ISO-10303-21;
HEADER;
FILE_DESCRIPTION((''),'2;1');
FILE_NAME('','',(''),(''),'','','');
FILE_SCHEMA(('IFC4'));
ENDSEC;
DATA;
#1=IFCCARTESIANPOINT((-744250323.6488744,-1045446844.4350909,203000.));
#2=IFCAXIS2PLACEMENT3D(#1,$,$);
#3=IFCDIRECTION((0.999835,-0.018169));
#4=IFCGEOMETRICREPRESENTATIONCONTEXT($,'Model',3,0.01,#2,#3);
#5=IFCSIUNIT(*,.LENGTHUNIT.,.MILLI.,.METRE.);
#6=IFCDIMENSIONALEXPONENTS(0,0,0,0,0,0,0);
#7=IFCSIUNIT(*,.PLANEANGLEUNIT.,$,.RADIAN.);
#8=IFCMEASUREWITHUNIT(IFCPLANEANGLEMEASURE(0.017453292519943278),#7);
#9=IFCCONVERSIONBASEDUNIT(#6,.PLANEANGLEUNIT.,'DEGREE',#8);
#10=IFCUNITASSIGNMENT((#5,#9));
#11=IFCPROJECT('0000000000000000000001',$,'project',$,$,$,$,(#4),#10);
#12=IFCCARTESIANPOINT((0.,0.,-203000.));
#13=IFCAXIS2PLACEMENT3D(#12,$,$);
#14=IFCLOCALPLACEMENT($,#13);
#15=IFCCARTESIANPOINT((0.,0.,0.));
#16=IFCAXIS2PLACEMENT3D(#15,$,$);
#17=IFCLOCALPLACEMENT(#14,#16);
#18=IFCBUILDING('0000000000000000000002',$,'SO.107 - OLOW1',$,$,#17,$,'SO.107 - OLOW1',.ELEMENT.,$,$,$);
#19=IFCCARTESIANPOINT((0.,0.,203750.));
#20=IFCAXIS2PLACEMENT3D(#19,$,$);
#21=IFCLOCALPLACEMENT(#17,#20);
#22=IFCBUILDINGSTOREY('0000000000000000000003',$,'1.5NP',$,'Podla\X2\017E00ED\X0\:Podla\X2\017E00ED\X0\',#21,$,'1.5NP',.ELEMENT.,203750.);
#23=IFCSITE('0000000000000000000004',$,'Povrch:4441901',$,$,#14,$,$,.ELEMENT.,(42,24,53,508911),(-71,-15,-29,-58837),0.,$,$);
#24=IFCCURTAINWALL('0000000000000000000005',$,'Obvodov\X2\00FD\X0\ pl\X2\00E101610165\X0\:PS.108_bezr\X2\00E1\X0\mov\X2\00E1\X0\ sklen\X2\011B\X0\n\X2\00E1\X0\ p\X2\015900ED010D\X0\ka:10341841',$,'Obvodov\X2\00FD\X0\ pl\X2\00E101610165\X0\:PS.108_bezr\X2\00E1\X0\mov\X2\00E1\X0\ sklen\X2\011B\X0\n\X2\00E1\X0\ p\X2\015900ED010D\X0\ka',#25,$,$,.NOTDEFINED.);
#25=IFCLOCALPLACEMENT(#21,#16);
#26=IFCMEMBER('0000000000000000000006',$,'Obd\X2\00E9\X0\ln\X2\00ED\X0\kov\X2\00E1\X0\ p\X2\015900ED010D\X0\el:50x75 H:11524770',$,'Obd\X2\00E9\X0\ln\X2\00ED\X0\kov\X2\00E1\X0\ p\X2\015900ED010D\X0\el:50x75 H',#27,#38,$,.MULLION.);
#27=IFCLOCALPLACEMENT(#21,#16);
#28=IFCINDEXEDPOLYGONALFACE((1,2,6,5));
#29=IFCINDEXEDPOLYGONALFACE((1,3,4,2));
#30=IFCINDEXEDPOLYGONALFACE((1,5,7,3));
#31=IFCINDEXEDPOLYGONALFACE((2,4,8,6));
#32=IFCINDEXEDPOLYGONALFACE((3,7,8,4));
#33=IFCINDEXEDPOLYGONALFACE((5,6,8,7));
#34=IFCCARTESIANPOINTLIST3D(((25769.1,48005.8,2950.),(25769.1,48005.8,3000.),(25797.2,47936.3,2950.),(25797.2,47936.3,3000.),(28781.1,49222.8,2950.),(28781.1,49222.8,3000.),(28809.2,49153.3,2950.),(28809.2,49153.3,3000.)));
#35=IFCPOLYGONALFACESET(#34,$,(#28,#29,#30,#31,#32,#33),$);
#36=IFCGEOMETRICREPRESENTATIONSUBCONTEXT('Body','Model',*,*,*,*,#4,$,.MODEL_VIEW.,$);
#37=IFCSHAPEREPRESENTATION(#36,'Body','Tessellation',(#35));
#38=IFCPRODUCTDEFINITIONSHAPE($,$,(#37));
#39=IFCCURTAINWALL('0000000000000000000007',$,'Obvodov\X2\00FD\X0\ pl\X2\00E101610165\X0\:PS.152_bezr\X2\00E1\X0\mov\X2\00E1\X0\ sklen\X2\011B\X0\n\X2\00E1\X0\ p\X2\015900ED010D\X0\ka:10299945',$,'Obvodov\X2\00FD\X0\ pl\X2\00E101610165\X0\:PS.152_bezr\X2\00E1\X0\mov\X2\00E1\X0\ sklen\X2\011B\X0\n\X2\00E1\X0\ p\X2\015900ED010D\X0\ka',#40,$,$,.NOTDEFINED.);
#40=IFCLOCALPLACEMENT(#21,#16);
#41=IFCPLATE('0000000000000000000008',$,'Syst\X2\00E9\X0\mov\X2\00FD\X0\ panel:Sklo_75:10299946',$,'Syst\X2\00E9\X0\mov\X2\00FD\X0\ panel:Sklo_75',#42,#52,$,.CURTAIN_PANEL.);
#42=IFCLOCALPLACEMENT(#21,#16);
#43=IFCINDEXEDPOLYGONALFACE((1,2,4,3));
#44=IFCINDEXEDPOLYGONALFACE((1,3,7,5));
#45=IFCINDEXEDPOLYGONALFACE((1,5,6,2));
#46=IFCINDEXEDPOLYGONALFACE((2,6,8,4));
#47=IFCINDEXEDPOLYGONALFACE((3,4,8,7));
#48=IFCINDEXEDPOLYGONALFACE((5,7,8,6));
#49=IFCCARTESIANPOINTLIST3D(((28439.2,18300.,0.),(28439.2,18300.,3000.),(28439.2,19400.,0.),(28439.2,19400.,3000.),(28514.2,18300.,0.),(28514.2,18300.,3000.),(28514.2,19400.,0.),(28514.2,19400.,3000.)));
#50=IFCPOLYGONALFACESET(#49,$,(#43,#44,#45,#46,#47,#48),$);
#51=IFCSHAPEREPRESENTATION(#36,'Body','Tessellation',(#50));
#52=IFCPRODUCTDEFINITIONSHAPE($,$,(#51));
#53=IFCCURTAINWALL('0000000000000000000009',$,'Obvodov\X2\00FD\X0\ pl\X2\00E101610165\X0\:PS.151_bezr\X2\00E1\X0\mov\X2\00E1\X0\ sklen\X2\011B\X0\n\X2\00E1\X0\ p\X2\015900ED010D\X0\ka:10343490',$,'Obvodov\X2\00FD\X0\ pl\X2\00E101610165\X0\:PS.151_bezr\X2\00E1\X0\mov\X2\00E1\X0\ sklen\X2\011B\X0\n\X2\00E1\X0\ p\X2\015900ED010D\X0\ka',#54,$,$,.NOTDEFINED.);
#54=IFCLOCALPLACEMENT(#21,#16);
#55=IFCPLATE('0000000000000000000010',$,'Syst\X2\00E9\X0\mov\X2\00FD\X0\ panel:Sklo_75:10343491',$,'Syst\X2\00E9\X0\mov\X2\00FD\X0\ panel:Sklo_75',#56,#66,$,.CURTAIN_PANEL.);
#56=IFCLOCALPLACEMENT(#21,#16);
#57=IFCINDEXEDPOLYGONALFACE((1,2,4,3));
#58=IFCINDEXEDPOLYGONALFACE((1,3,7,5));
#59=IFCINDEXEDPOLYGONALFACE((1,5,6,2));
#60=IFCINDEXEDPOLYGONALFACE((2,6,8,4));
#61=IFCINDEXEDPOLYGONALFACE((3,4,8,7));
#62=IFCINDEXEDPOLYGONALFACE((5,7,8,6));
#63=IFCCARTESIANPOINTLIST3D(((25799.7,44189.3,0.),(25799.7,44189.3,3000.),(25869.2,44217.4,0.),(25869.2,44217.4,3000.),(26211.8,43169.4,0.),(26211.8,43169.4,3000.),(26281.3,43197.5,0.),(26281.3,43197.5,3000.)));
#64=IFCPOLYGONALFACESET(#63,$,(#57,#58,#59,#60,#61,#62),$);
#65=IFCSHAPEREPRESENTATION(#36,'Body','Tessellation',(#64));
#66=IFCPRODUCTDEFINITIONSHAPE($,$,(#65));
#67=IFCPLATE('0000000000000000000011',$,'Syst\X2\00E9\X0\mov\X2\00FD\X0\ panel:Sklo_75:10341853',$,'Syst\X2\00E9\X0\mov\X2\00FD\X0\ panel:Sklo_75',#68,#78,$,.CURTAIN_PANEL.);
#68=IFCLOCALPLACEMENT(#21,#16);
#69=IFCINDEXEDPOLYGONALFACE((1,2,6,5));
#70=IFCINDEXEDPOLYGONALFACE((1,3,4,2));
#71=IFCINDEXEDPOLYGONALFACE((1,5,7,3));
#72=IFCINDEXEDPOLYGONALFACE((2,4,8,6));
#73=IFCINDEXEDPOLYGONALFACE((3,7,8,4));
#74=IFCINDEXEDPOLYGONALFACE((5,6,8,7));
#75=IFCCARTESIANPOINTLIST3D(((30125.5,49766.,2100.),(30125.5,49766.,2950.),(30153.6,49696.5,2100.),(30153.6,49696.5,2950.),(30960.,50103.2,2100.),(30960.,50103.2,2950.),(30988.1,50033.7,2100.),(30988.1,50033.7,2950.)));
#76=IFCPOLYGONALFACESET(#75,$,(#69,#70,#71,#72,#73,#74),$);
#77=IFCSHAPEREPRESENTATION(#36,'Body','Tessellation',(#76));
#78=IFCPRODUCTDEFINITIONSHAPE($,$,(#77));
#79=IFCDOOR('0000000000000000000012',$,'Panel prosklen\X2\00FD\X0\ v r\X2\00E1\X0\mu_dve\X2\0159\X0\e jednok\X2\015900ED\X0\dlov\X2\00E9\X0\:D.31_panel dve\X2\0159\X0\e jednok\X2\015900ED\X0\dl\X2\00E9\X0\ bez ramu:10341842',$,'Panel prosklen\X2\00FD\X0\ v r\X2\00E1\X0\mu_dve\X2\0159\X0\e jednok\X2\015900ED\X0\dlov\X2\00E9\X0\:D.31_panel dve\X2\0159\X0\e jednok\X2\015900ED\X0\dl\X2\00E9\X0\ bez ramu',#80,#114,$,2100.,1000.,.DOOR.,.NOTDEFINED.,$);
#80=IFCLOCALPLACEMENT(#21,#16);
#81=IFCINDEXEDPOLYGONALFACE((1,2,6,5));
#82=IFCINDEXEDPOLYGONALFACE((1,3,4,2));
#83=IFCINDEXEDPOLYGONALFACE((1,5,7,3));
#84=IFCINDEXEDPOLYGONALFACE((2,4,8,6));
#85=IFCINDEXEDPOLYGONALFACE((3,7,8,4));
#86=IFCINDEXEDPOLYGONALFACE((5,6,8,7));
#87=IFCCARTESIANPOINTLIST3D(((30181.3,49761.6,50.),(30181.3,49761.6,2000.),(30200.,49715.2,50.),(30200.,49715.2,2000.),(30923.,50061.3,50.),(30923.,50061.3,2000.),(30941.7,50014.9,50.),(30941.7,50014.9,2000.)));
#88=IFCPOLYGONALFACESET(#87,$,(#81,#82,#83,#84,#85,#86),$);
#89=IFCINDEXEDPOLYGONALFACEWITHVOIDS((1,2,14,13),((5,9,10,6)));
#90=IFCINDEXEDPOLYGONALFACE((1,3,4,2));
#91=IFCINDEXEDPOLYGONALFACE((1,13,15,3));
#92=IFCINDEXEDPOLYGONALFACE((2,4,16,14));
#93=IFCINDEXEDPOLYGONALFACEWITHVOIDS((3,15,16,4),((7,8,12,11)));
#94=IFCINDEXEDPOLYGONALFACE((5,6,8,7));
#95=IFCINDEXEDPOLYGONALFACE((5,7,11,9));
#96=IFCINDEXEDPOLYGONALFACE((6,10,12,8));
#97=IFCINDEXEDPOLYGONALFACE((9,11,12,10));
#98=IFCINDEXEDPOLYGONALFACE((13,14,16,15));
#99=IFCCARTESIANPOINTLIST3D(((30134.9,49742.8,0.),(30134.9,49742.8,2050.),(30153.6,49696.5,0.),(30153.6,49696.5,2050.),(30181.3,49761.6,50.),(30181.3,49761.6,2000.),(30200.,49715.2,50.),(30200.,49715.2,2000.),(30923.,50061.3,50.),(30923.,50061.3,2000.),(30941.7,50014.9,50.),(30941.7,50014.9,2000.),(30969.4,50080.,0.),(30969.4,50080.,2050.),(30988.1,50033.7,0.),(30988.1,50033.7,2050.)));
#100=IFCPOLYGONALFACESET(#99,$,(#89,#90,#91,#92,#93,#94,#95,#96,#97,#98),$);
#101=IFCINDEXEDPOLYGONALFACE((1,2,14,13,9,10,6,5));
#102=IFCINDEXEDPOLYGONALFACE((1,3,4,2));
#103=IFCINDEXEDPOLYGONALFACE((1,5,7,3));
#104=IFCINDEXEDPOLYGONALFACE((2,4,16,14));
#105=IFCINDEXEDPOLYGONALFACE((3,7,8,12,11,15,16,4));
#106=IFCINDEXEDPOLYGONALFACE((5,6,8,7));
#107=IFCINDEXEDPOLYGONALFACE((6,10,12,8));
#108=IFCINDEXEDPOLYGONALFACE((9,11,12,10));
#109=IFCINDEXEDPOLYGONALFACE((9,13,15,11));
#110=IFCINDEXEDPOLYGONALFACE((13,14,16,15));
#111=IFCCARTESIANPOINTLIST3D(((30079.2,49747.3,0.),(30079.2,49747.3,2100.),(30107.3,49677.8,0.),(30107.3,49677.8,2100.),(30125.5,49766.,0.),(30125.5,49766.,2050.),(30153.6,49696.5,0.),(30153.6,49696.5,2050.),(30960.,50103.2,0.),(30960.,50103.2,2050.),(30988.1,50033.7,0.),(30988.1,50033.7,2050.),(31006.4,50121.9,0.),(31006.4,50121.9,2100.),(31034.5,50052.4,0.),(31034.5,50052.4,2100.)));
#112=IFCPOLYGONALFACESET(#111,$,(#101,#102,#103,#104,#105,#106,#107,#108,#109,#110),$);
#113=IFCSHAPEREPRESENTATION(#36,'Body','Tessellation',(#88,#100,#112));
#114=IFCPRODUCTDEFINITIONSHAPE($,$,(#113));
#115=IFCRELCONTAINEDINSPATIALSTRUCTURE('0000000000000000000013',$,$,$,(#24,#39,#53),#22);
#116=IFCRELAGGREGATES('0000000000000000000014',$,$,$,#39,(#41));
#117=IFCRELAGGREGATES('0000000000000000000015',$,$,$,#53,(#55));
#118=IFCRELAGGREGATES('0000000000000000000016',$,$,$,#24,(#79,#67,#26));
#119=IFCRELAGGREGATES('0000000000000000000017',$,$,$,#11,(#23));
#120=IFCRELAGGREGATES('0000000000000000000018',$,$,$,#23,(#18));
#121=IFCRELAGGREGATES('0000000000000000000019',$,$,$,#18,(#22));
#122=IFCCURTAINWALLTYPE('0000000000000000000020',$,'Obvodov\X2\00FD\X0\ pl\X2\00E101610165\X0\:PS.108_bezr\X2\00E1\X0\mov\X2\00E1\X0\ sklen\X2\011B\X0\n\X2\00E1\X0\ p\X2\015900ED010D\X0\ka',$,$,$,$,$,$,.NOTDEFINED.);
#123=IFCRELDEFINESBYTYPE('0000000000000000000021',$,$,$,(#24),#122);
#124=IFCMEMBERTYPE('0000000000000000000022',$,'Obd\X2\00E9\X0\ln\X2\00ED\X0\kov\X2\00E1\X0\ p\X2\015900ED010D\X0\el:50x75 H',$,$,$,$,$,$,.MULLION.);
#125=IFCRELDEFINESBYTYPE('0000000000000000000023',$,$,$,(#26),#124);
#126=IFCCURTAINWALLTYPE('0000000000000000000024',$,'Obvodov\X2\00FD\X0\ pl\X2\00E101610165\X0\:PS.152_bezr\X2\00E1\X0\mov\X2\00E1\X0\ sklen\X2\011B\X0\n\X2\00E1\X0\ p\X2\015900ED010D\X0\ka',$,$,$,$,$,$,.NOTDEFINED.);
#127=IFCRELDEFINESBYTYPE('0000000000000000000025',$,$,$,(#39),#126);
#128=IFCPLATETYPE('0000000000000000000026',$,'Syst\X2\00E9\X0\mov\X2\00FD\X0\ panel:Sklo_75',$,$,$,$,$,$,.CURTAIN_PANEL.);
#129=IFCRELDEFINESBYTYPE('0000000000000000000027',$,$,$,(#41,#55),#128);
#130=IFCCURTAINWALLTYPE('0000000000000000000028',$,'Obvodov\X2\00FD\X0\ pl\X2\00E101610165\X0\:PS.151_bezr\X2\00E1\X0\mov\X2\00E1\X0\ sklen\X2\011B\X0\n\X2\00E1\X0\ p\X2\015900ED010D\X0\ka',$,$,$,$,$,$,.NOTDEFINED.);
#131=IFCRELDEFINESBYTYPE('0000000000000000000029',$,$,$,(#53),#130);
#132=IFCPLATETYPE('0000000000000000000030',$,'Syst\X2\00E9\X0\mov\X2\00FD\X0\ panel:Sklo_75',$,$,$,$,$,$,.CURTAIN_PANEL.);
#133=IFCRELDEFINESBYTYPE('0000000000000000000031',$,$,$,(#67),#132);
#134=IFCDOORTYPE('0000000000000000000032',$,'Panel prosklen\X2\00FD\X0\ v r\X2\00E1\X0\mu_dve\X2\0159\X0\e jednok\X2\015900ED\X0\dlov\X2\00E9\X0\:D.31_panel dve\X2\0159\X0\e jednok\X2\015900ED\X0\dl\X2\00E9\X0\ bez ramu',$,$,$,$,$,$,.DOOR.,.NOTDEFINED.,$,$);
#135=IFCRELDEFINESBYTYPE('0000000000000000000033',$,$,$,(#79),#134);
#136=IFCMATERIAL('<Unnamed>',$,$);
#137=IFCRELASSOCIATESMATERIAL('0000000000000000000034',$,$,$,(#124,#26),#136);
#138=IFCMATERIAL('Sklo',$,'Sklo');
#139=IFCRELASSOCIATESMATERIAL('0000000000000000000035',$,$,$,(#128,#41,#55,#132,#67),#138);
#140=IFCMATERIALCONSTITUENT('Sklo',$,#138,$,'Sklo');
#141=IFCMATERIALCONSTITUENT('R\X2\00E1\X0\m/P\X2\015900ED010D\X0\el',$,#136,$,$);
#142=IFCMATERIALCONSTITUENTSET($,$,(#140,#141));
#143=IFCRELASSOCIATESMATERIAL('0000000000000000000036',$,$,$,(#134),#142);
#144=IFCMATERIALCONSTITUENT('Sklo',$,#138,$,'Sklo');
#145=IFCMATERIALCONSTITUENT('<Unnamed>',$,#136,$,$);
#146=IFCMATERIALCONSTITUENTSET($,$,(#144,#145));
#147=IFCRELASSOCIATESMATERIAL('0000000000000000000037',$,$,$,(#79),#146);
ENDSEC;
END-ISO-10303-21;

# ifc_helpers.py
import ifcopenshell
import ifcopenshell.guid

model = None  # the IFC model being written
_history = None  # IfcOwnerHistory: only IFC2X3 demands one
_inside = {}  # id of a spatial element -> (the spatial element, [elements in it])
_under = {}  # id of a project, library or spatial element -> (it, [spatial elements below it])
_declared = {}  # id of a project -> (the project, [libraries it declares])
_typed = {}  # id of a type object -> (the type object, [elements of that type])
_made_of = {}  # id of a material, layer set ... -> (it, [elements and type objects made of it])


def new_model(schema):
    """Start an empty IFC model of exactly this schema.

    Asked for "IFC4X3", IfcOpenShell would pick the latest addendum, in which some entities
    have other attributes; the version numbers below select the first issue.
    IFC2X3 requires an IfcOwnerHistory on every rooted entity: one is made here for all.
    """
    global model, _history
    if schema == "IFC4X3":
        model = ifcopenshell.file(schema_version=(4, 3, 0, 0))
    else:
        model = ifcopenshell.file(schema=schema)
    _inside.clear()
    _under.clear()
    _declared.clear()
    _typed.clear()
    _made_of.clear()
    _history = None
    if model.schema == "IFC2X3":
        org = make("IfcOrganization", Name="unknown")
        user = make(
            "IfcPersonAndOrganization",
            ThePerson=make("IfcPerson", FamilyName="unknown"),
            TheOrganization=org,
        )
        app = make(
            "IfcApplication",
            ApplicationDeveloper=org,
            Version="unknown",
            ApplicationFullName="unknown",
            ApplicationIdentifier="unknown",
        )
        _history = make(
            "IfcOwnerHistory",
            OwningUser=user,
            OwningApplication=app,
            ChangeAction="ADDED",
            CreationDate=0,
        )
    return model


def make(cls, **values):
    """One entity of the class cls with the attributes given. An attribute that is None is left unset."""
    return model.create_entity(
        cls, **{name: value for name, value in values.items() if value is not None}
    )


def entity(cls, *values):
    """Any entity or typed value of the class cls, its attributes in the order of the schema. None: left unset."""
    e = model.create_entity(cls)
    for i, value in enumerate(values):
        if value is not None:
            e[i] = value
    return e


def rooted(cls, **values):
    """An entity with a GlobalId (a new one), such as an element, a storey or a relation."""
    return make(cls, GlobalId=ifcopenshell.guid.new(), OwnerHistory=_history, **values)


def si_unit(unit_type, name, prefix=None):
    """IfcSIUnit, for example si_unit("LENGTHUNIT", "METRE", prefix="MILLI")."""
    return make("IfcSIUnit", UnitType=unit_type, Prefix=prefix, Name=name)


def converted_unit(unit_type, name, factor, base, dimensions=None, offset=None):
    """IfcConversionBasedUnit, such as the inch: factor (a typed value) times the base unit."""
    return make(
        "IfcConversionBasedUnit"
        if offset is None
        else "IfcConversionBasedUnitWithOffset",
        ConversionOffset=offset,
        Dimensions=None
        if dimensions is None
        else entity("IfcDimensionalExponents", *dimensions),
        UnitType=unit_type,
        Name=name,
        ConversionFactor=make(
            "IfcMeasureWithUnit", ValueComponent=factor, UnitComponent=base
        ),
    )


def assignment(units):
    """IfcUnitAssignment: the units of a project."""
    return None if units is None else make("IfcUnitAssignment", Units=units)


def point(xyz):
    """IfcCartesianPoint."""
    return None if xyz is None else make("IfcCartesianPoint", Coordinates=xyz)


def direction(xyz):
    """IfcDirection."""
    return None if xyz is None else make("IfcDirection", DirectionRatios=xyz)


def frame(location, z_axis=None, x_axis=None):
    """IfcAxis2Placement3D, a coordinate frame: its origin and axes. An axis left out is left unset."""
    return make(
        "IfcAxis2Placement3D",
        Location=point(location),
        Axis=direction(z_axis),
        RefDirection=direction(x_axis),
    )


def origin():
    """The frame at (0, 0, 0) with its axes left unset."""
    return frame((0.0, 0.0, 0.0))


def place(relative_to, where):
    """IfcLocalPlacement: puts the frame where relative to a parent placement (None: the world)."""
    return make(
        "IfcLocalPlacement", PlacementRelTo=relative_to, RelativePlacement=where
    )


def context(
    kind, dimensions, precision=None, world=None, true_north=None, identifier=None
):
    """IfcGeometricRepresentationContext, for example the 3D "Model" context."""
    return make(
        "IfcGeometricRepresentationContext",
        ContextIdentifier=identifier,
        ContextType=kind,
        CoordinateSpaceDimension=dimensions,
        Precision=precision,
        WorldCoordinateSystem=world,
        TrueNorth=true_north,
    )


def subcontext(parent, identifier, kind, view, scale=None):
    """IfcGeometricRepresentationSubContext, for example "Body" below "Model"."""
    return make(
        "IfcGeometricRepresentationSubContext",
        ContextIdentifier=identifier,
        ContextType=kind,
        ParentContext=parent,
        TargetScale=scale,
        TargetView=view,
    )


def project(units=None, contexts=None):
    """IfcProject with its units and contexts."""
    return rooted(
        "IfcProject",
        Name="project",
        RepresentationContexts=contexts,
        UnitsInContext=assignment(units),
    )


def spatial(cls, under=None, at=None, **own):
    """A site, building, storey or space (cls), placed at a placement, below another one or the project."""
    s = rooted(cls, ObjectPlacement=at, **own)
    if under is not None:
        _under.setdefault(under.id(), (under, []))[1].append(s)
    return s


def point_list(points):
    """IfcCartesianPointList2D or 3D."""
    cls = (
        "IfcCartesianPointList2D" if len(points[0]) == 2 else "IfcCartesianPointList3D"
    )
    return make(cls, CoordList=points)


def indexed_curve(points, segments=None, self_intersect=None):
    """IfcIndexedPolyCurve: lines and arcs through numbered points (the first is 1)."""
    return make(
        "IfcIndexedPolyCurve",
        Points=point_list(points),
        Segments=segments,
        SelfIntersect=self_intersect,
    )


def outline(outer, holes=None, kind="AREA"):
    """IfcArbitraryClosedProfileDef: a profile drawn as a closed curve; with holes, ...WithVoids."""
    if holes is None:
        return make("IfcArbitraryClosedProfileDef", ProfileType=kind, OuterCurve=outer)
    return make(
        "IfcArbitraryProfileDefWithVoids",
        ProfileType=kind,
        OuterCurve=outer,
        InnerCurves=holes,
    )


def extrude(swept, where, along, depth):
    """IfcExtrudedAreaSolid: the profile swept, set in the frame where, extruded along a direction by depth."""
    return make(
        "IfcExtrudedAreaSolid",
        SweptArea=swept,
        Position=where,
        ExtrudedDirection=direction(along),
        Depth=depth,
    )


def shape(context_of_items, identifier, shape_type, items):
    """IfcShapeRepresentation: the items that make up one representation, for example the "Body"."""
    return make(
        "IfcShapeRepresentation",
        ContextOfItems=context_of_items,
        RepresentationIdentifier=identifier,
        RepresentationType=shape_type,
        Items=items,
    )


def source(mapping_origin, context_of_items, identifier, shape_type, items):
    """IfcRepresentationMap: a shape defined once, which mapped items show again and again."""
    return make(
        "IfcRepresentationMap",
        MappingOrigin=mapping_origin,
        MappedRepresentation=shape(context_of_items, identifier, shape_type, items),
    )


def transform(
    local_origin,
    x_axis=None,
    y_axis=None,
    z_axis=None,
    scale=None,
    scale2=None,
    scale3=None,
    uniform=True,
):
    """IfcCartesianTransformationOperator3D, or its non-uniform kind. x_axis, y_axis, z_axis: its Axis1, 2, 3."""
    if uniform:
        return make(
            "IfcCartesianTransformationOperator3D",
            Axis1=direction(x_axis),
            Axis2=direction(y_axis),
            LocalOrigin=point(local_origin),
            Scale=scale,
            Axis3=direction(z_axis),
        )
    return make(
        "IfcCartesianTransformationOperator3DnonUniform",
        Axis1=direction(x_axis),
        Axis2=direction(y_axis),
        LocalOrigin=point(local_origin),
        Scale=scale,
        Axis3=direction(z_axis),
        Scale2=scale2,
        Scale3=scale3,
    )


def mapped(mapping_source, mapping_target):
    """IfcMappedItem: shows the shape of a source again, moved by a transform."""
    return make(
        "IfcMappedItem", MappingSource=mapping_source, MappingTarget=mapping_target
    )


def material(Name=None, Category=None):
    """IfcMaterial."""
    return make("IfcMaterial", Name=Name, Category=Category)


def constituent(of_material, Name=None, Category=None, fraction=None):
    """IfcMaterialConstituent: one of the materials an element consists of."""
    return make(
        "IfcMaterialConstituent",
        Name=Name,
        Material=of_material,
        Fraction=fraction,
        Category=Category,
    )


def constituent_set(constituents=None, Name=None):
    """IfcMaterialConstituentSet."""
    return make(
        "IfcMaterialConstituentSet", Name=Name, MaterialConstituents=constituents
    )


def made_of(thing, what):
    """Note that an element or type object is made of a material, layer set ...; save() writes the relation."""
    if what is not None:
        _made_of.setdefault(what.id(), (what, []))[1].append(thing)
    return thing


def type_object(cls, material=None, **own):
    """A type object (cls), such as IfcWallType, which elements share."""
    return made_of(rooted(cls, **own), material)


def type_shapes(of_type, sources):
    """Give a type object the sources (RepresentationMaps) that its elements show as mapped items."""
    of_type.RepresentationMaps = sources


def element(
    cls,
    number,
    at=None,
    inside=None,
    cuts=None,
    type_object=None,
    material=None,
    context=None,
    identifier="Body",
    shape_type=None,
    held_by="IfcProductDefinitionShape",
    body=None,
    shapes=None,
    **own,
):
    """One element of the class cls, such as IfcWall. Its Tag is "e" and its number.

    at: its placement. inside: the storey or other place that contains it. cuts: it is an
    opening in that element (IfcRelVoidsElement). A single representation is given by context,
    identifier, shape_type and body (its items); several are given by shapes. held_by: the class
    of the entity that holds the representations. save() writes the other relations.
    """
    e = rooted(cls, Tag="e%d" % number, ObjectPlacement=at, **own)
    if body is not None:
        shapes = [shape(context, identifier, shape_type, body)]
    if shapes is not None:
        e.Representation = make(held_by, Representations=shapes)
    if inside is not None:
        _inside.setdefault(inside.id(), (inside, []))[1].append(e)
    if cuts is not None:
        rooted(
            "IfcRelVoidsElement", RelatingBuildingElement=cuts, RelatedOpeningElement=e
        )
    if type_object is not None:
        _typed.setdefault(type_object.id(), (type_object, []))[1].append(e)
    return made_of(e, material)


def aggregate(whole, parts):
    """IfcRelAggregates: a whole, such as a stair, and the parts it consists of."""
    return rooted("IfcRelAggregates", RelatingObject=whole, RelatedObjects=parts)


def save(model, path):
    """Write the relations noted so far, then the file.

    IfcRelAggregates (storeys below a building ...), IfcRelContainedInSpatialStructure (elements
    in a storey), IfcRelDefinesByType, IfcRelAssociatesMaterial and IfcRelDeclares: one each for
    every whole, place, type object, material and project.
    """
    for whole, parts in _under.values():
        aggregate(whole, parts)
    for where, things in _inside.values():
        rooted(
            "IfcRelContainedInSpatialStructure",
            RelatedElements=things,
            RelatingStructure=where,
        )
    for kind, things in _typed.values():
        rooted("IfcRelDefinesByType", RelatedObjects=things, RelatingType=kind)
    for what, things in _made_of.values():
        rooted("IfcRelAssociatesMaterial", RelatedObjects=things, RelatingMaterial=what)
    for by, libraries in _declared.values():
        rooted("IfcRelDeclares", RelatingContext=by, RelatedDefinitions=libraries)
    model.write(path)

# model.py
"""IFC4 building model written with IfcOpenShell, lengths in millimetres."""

from ifc_helpers import new_model, entity, si_unit, converted_unit, direction, frame, origin, place, context, subcontext, project, spatial, indexed_curve, outline, extrude, source, transform, mapped, material, constituent, constituent_set, type_object, type_shapes, element, aggregate, save


model = new_model("IFC4")

# Units and contexts
model_context = context("Model", 3, precision=0.01, world=frame((-744250323.6488744, -1045446844.4350909, 203000.0)), true_north=direction((0.999835, -0.018169)))
body_context = subcontext(model_context, "Body", "Model", "MODEL_VIEW")
ifc_project = project(units=[si_unit("LENGTHUNIT", "METRE", prefix="MILLI"), converted_unit("PLANEANGLEUNIT", "DEGREE", entity("IfcPlaneAngleMeasure", 0.017453292519943278), si_unit("PLANEANGLEUNIT", "RADIAN"), dimensions=[0, 0, 0, 0, 0, 0, 0])], contexts=[model_context])

# Site, building, storey
site_placement = place(None, frame((0.0, 0.0, -203000.0)))
site = spatial("IfcSite", under=ifc_project, at=site_placement, Name="Povrch:4441901", CompositionType="ELEMENT", RefLatitude=(42, 24, 53, 508911), RefLongitude=(-71, -15, -29, -58837), RefElevation=0.0)
building_placement = place(site_placement, origin())
building = spatial("IfcBuilding", under=site, at=building_placement, Name="SO.107 - OLOW1", LongName="SO.107 - OLOW1", CompositionType="ELEMENT")
storey_placement = place(building_placement, frame((0.0, 0.0, 203750.0)))
storey = spatial("IfcBuildingStorey", under=building, at=storey_placement, Name="1.5NP", ObjectType="Podlaží:Podlaží", LongName="1.5NP", CompositionType="ELEMENT", Elevation=203750.0)

# Curtain wall, member
ifc_material_1 = material(Name="<Unnamed>")
curtain_wall_type_1 = type_object("IfcCurtainWallType", Name="Obvodový plášť:PS.108_bezrámová skleněná příčka", PredefinedType="NOTDEFINED")
curtain_wall_1_placement = place(storey_placement, frame((0.0, 0.0, -203750.0)))
curtain_wall_1 = element("IfcCurtainWall", 1, at=curtain_wall_1_placement, inside=storey, type_object=curtain_wall_type_1, Name="Obvodový plášť:PS.108_bezrámová skleněná příčka:10341841", ObjectType="Obvodový plášť:PS.108_bezrámová skleněná příčka", PredefinedType="NOTDEFINED")
member_type_1 = type_object("IfcMemberType", Name="Obdélníková příčel:50x75 H", PredefinedType="MULLION", material=ifc_material_1)
shared_shape_1 = source(origin(), body_context, "Body", "SweptSolid", [
    extrude(outline(indexed_curve([(-25.0, -37.5), (25.0, -37.5), (25.0, 37.5), (-25.0, 37.5), (-25.0, -37.5)], self_intersect=False)), frame((-25.0, -37.5, -3248.6), z_axis=(0.0, 0.0, 1.0), x_axis=(-1.0, 0.0, 0.0)), (0.0, 0.0, 1.0), 3248.6),
])
type_shapes(member_type_1, [shared_shape_1])
member_1_placement = place(curtain_wall_1_placement, frame((25769.1, 48005.8, 206750.0), z_axis=(-0.927176, -0.374626, 0.0), x_axis=(0.0, 0.0, 1.0)))
member_1 = element("IfcMember", 2, at=member_1_placement, type_object=member_type_1, material=ifc_material_1, Name="Obdélníková příčel:50x75 H:11524770", ObjectType="Obdélníková příčel:50x75 H", PredefinedType="MULLION", context=body_context, shape_type="MappedRepresentation", body=[
    mapped(shared_shape_1, transform((0.0, 0.0, 0.0), scale=1.0)),
])

# Curtain walls, plates
curtain_wall_type_2 = type_object("IfcCurtainWallType", Name="Obvodový plášť:PS.152_bezrámová skleněná příčka", PredefinedType="NOTDEFINED")
curtain_wall_2_placement = place(storey_placement, frame((0.0, 0.0, -203750.0)))
curtain_wall_2 = element("IfcCurtainWall", 3, at=curtain_wall_2_placement, inside=storey, type_object=curtain_wall_type_2, Name="Obvodový plášť:PS.152_bezrámová skleněná příčka:10299945", ObjectType="Obvodový plášť:PS.152_bezrámová skleněná příčka", PredefinedType="NOTDEFINED")
ifc_material_2 = material(Name="Sklo", Category="Sklo")
plate_type_1 = type_object("IfcPlateType", Name="Systémový panel:Sklo_75", PredefinedType="CURTAIN_PANEL", material=ifc_material_2)
shared_shape_2 = source(origin(), body_context, "Body", "SweptSolid", [
    extrude(outline(indexed_curve([(-37.5, -550.0), (37.5, -550.0), (37.5, 550.0), (-37.5, 550.0), (-37.5, -550.0)], self_intersect=False)), frame((0.0, -37.5, 0.0), z_axis=(0.0, 0.0, 1.0), x_axis=(0.0, 1.0, 0.0)), (0.0, 0.0, 1.0), 3000.0),
])
type_shapes(plate_type_1, [shared_shape_2])
plate_1_placement = place(curtain_wall_2_placement, frame((28514.2, 18850.0, 203750.0), z_axis=(0.0, 0.0, 1.0), x_axis=(0.0, -1.0, 0.0)))
plate_1 = element("IfcPlate", 4, at=plate_1_placement, type_object=plate_type_1, material=ifc_material_2, Name="Systémový panel:Sklo_75:10299946", ObjectType="Systémový panel:Sklo_75", PredefinedType="CURTAIN_PANEL", context=body_context, shape_type="MappedRepresentation", body=[
    mapped(shared_shape_2, transform((0.0, 0.0, 0.0), scale=1.0)),
])
aggregate(curtain_wall_2, [plate_1])
curtain_wall_type_3 = type_object("IfcCurtainWallType", Name="Obvodový plášť:PS.151_bezrámová skleněná příčka", PredefinedType="NOTDEFINED")
curtain_wall_3_placement = place(storey_placement, frame((0.0, 0.0, -203750.0)))
curtain_wall_3 = element("IfcCurtainWall", 5, at=curtain_wall_3_placement, inside=storey, type_object=curtain_wall_type_3, Name="Obvodový plášť:PS.151_bezrámová skleněná příčka:10343490", ObjectType="Obvodový plášť:PS.151_bezrámová skleněná příčka", PredefinedType="NOTDEFINED")
plate_2_placement = place(curtain_wall_3_placement, frame((26075.3, 43707.5, 203750.0), z_axis=(0.0, 0.0, 1.0), x_axis=(0.374626, -0.927176, 0.0)))
plate_2 = element("IfcPlate", 6, at=plate_2_placement, type_object=plate_type_1, material=ifc_material_2, Name="Systémový panel:Sklo_75:10343491", ObjectType="Systémový panel:Sklo_75", PredefinedType="CURTAIN_PANEL", context=body_context, shape_type="MappedRepresentation", body=[
    mapped(shared_shape_2, transform((0.0, 0.0, 0.0), scale=1.0)),
])
aggregate(curtain_wall_3, [plate_2])

# Plate
plate_type_2 = type_object("IfcPlateType", Name="Systémový panel:Sklo_75", PredefinedType="CURTAIN_PANEL", material=ifc_material_2)
shared_shape_3 = source(origin(), body_context, "Body", "SweptSolid", [
    extrude(outline(indexed_curve([(-37.5, -450.0), (37.5, -450.0), (37.5, 450.0), (-37.5, 450.0), (-37.5, -450.0)], self_intersect=False)), frame((0.0, 37.5, 0.0), z_axis=(0.0, 0.0, 1.0), x_axis=(0.0, 1.0, 0.0)), (0.0, 0.0, 1.0), 850.0),
])
type_shapes(plate_type_2, [shared_shape_3])
plate_3_placement = place(curtain_wall_1_placement, frame((30542.8, 49934.6, 205850.0), z_axis=(0.0, 0.0, 1.0), x_axis=(-0.927176, -0.374626, 0.0)))
plate_3 = element("IfcPlate", 7, at=plate_3_placement, type_object=plate_type_2, material=ifc_material_2, Name="Systémový panel:Sklo_75:10341853", ObjectType="Systémový panel:Sklo_75", PredefinedType="CURTAIN_PANEL", context=body_context, shape_type="MappedRepresentation", body=[
    mapped(shared_shape_3, transform((0.0, 0.0, 0.0), scale=1.0)),
])

# Door
ifc_constituent_1 = constituent(ifc_material_2, Name="Sklo", Category="Sklo")
ifc_constituent_2 = constituent(ifc_material_1, Name="<Unnamed>")
ifc_constituent_set_1 = constituent_set(constituents=[ifc_constituent_1, ifc_constituent_2])
ifc_constituent_3 = constituent(ifc_material_2, Name="Sklo", Category="Sklo")
ifc_constituent_4 = constituent(ifc_material_1, Name="Rám/Příčel")
ifc_constituent_set_2 = constituent_set(constituents=[ifc_constituent_3, ifc_constituent_4])
door_type = type_object("IfcDoorType", Name="Panel prosklený v rámu_dveře jednokřídlové:D.31_panel dveře jednokřídlé bez ramu", OperationType="NOTDEFINED", PredefinedType="DOOR", material=ifc_constituent_set_2)
shared_shape_4 = source(origin(), body_context, "Body", "SweptSolid", [
    extrude(outline(indexed_curve([(-25.0, -400.0), (25.0, -400.0), (25.0, 400.0), (-25.0, 400.0), (-25.0, -400.0)], self_intersect=False)), frame((0.0, -50.0, 50.0), z_axis=(0.0, 0.0, 1.0), x_axis=(0.0, -1.0, 0.0)), (0.0, 0.0, 1.0), 1950.0),
    extrude(outline(indexed_curve([(-1025.0, -450.0), (1025.0, -450.0), (1025.0, 450.0), (-1025.0, 450.0), (-1025.0, -450.0)], self_intersect=False), holes=[indexed_curve([(-975.0, -400.0), (-975.0, 400.0), (975.0, 400.0), (975.0, -400.0), (-975.0, -400.0)], self_intersect=False)]), frame((0.0, -25.0, 1025.0), z_axis=(0.0, -1.0, 0.0), x_axis=(0.0, 0.0, -1.0)), (0.0, 0.0, 1.0), 50.0),
    extrude(outline(indexed_curve([(-1062.5, -500.0), (1037.5, -500.0), (1037.5, -450.0), (-1012.5, -450.0), (-1012.5, 450.0), (1037.5, 450.0), (1037.5, 500.0), (-1062.5, 500.0), (-1062.5, -500.0)], self_intersect=False)), frame((0.0, 0.0, 1037.5), z_axis=(0.0, -1.0, 0.0), x_axis=(0.0, 0.0, -1.0)), (0.0, 0.0, 1.0), 75.0),
])
type_shapes(door_type, [shared_shape_4])
door_placement = place(curtain_wall_1_placement, frame((30542.8, 49934.6, 203750.0), z_axis=(0.0, 0.0, 1.0), x_axis=(0.927176, 0.374626, 0.0)))
door = element("IfcDoor", 8, at=door_placement, type_object=door_type, material=ifc_constituent_set_1, Name="Panel prosklený v rámu_dveře jednokřídlové:D.31_panel dveře jednokřídlé bez ramu:10341842", ObjectType="Panel prosklený v rámu_dveře jednokřídlové:D.31_panel dveře jednokřídlé bez ramu", OperationType="NOTDEFINED", OverallHeight=2100.0, OverallWidth=1000.0, PredefinedType="DOOR", context=body_context, shape_type="MappedRepresentation", body=[
    mapped(shared_shape_4, transform((0.0, 0.0, 0.0), scale=1.0)),
])
aggregate(curtain_wall_1, [door, plate_3, member_1])

save(model, "model.ifc")
